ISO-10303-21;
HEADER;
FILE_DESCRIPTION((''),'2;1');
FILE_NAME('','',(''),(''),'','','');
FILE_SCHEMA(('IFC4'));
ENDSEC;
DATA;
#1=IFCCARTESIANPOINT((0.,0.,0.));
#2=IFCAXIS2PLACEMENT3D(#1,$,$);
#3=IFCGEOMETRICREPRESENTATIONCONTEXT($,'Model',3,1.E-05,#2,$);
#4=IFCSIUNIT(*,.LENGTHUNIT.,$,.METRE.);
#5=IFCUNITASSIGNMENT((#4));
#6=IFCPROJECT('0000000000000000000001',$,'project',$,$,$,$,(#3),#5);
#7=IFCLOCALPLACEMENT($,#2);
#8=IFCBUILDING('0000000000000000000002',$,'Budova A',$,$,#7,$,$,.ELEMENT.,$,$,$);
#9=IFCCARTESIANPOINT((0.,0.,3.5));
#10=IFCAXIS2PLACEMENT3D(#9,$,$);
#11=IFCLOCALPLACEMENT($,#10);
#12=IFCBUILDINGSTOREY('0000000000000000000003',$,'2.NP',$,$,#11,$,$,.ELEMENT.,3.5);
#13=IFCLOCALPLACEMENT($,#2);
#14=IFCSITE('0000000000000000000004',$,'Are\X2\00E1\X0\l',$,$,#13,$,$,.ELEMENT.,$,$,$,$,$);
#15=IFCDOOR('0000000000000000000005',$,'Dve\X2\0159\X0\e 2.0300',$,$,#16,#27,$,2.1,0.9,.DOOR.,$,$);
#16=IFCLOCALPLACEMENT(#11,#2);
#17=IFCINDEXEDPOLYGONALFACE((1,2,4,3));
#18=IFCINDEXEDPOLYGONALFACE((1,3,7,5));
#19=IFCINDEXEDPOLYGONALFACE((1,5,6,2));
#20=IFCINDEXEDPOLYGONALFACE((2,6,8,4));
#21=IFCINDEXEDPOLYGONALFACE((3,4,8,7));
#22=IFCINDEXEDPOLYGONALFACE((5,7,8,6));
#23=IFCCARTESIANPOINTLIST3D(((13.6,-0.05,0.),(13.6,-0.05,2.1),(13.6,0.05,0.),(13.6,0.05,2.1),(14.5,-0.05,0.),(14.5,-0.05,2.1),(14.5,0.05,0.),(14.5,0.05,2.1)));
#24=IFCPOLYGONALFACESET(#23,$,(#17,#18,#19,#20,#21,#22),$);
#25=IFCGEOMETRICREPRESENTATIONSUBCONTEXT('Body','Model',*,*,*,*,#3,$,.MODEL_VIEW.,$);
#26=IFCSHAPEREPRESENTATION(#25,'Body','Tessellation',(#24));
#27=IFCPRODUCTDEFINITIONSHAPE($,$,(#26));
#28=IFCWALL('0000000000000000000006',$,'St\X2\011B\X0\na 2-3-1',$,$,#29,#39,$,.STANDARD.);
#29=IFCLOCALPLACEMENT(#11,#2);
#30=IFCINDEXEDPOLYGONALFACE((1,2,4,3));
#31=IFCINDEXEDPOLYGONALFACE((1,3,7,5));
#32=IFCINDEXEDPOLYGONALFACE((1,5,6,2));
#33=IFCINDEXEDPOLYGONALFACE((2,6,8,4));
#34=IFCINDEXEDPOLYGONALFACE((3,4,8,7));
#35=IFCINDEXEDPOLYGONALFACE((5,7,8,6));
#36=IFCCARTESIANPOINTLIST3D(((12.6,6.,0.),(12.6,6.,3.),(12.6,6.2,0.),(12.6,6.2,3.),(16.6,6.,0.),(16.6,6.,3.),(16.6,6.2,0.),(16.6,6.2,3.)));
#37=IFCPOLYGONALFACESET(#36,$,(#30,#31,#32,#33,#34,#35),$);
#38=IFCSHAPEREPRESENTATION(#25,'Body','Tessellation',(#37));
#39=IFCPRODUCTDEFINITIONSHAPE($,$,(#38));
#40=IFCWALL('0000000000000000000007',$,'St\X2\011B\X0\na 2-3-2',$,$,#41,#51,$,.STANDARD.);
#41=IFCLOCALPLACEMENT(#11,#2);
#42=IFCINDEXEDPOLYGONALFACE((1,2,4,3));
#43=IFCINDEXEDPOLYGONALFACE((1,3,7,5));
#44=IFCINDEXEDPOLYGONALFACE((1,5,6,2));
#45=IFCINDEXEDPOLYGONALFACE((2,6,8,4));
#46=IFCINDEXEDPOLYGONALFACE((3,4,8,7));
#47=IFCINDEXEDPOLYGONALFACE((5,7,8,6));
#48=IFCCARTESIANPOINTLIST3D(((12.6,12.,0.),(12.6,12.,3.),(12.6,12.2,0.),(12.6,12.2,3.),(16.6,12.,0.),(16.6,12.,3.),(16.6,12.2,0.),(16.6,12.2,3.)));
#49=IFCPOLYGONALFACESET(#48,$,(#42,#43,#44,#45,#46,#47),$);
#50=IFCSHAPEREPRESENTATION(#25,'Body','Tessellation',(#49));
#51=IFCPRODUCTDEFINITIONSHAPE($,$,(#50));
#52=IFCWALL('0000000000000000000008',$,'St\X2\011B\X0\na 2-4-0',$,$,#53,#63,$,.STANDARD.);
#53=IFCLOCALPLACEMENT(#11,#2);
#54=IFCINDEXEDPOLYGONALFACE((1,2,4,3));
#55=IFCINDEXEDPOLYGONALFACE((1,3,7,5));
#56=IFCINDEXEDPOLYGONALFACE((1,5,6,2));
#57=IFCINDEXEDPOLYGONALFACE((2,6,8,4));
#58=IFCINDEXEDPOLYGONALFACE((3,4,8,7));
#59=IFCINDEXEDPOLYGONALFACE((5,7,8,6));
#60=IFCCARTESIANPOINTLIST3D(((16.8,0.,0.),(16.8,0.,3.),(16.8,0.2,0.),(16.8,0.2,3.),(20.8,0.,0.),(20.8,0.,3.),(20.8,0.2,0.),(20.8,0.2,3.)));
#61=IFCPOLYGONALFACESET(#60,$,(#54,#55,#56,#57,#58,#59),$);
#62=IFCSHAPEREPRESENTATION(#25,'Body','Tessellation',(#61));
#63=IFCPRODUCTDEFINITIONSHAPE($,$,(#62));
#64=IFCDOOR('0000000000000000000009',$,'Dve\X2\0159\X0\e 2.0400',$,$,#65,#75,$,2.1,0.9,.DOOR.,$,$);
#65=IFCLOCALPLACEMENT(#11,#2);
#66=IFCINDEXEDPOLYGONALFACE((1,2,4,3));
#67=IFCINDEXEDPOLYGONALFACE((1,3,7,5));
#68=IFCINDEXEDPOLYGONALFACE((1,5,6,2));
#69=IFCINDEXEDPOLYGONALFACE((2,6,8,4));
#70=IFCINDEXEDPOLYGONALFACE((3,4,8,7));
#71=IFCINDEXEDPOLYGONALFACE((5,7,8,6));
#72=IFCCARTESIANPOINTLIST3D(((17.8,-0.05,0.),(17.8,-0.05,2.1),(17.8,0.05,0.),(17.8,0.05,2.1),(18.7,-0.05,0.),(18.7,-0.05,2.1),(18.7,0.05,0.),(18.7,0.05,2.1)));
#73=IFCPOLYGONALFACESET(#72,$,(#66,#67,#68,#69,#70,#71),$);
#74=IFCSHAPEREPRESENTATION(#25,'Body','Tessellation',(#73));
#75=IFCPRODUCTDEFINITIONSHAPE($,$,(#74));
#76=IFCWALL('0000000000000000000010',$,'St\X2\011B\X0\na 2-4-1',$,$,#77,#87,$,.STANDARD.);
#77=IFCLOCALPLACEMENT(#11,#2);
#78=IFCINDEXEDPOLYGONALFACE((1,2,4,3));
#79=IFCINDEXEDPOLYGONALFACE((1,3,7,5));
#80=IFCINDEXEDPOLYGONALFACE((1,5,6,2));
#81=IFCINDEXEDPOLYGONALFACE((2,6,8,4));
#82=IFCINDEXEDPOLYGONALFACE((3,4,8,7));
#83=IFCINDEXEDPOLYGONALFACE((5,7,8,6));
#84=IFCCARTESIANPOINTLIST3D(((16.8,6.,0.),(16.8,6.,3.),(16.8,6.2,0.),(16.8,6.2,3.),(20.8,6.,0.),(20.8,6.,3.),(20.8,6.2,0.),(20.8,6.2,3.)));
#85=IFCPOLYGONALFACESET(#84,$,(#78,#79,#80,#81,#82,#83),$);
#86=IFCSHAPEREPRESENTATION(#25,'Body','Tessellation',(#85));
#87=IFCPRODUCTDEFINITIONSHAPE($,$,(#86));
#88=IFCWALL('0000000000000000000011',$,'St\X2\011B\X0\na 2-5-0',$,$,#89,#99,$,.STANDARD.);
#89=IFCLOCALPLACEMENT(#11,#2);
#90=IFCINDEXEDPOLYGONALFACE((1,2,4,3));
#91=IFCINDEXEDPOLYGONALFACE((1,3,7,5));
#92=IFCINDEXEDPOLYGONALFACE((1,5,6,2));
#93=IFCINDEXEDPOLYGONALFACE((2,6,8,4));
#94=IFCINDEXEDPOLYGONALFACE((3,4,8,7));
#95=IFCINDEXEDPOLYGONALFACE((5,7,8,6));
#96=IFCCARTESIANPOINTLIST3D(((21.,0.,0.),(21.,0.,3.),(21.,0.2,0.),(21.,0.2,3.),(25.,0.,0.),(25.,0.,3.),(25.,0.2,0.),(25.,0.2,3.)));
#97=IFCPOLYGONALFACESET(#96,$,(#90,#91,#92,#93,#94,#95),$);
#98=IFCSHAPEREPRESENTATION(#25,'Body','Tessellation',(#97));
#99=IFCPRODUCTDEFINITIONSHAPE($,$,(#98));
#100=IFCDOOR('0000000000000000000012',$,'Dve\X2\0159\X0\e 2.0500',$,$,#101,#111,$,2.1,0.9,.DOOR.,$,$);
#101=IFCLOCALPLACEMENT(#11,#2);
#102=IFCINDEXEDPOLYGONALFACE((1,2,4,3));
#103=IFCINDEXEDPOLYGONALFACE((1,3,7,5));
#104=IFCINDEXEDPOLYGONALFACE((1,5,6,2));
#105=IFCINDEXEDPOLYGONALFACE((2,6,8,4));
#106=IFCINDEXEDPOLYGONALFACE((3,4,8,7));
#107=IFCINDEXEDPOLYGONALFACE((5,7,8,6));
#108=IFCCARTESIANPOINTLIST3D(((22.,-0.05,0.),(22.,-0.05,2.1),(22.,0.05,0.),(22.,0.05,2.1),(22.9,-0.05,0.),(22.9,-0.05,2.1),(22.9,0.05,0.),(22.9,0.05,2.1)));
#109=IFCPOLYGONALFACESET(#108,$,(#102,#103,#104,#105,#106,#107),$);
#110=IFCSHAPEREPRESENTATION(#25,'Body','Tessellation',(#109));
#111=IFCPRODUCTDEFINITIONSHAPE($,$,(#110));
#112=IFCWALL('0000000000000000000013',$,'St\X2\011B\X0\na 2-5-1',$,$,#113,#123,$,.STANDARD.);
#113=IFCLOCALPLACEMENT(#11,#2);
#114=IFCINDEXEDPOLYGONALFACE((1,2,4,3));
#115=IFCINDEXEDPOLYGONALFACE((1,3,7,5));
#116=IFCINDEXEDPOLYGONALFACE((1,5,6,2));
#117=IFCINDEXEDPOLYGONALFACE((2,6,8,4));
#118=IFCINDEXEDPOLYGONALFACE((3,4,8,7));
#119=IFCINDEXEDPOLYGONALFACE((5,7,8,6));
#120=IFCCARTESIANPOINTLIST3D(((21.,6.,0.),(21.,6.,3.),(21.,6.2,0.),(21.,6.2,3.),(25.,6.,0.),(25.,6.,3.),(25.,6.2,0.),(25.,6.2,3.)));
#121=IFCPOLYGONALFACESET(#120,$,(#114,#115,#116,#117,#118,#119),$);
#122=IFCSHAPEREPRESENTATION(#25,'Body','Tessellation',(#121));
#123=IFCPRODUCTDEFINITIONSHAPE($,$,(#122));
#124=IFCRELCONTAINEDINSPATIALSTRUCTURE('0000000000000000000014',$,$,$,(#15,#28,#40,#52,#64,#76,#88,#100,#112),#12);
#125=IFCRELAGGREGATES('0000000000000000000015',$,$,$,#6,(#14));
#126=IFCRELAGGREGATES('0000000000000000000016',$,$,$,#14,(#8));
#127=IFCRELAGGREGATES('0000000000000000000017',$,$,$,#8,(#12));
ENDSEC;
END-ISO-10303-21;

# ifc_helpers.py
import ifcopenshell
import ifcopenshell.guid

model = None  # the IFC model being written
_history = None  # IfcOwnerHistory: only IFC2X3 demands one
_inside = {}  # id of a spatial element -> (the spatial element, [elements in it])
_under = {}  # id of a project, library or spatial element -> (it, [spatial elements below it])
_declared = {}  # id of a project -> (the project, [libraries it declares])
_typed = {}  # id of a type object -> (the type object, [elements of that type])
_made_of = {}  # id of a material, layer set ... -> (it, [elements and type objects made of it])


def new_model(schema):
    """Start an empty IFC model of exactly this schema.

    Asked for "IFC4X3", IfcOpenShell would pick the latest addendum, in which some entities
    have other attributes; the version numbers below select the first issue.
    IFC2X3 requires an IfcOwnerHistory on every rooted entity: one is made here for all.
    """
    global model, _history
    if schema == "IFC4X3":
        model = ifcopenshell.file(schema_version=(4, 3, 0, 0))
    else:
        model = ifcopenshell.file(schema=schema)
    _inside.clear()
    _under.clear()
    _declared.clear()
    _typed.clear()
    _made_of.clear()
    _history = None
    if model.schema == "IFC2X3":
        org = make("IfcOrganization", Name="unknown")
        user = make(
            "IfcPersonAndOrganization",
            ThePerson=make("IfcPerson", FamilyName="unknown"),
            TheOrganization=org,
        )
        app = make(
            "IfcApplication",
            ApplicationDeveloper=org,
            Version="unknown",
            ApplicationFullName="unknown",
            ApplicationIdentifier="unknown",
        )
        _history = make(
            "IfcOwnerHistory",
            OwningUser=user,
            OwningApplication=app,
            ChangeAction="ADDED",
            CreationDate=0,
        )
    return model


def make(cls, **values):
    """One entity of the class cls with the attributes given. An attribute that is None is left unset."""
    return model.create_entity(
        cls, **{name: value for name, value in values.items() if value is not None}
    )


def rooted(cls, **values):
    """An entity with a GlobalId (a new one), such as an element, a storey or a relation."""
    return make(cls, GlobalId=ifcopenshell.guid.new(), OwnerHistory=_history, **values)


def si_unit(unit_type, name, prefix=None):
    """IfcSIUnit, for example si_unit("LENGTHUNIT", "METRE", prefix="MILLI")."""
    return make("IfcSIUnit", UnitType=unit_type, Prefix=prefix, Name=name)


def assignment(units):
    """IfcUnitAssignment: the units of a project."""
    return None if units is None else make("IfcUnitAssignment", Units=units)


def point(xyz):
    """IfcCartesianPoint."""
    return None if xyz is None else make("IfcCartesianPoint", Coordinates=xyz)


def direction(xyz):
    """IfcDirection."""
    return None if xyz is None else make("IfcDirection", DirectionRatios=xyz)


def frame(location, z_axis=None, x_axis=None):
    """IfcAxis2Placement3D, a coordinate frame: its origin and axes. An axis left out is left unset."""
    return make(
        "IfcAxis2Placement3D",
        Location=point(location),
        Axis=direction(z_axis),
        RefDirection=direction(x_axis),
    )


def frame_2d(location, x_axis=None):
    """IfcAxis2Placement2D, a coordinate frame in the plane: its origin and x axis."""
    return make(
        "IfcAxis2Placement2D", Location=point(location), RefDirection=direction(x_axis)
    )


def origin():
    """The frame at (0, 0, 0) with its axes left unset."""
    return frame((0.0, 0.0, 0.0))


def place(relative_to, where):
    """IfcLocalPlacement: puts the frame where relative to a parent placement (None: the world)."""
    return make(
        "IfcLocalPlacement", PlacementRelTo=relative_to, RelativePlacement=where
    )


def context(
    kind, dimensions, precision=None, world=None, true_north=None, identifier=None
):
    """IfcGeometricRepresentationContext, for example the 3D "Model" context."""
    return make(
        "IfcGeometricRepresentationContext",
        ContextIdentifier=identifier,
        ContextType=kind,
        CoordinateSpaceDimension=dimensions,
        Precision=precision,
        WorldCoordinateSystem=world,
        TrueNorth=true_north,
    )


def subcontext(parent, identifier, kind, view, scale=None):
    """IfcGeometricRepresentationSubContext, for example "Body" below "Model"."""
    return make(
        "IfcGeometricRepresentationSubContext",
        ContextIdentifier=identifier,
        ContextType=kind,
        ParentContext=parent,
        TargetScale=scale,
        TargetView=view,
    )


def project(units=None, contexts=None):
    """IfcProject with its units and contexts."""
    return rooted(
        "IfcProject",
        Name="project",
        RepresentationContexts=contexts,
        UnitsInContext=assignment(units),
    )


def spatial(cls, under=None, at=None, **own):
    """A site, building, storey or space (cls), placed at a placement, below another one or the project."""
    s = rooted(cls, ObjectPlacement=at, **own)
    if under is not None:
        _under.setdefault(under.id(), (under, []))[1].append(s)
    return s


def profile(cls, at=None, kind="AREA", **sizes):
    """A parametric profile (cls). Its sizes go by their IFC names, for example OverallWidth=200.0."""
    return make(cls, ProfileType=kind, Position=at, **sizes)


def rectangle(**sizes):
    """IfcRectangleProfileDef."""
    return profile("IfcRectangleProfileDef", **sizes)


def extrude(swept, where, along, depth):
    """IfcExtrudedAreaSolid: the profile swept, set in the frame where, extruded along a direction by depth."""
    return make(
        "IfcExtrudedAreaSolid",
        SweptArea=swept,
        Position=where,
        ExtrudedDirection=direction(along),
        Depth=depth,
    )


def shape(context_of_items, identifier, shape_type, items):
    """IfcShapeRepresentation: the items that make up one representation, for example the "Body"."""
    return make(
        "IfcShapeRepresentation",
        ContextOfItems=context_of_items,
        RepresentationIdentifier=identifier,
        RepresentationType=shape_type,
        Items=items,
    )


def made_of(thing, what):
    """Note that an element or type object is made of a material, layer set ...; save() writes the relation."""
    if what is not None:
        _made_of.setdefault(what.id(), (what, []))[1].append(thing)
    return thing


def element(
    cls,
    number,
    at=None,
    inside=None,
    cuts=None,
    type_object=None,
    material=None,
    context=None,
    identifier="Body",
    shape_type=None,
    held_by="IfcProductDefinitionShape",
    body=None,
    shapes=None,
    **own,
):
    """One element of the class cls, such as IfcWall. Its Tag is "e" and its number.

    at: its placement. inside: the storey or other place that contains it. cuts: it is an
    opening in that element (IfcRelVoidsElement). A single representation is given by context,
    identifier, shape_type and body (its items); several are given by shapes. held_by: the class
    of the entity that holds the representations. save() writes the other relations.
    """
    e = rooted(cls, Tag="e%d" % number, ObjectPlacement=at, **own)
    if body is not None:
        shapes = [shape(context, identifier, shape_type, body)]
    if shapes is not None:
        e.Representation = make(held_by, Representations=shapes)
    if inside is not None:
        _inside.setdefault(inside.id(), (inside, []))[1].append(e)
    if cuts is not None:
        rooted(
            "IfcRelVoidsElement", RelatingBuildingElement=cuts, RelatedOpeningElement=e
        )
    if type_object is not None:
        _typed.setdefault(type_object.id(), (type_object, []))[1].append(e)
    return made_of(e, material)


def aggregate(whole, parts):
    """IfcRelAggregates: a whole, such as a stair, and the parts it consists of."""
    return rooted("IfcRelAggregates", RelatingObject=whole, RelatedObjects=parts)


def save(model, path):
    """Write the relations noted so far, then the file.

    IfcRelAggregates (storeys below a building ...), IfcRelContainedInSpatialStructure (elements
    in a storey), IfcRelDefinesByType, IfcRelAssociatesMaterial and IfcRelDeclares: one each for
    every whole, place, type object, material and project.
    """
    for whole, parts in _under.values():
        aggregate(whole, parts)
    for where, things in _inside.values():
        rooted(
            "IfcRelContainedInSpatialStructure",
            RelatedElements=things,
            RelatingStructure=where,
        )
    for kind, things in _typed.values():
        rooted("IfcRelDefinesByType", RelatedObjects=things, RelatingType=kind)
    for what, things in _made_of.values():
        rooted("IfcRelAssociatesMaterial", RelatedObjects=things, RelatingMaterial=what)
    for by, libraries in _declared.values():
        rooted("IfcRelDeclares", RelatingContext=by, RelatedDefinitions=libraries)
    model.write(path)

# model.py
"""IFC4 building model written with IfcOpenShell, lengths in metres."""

from ifc_helpers import new_model, si_unit, frame, frame_2d, origin, place, context, subcontext, project, spatial, rectangle, extrude, element, save


model = new_model("IFC4")

# Units and contexts
model_context = context("Model", 3, precision=1e-05, world=origin())
body_context = subcontext(model_context, "Body", "Model", "MODEL_VIEW")
ifc_project = project(units=[si_unit("LENGTHUNIT", "METRE")], contexts=[model_context])

# Site, building, storey
site_placement = place(None, origin())
site = spatial("IfcSite", under=ifc_project, at=site_placement, Name="Areál", CompositionType="ELEMENT")
building_placement = place(None, origin())
building = spatial("IfcBuilding", under=site, at=building_placement, Name="Budova A", CompositionType="ELEMENT")
storey_placement = place(None, frame((0.0, 0.0, 3.5)))
storey = spatial("IfcBuildingStorey", under=building, at=storey_placement, Name="2.NP", CompositionType="ELEMENT", Elevation=3.5)

# Door
door_1_placement = place(storey_placement, frame((13.6, -0.05, 0.0)))
element("IfcDoor", 1, at=door_1_placement, inside=storey, Name="Dveře 2.0300", OverallHeight=2.1, OverallWidth=0.9, PredefinedType="DOOR", context=body_context, shape_type="SweptSolid", body=[
    extrude(rectangle(XDim=0.9, YDim=0.1, at=frame_2d((0.45, 0.05))), origin(), (0.0, 0.0, 1.0), 2.1),
])

# Walls
for number, where, name in (
    (2, (12.6, 6.0, 0.0), "Stěna 2-3-1"),
    (3, (12.6, 12.0, 0.0), "Stěna 2-3-2"),
    (4, (16.8, 0.0, 0.0), "Stěna 2-4-0"),
):
    element("IfcWall", number, at=place(storey_placement, frame(where)), inside=storey, Name=name, PredefinedType="STANDARD", context=body_context, shape_type="SweptSolid", body=[
        extrude(rectangle(XDim=4.0, YDim=0.2, at=frame_2d((2.0, 0.1))), origin(), (0.0, 0.0, 1.0), 3.0),
    ])

# Door
door_2_placement = place(storey_placement, frame((17.8, -0.05, 0.0)))
element("IfcDoor", 5, at=door_2_placement, inside=storey, Name="Dveře 2.0400", OverallHeight=2.1, OverallWidth=0.9, PredefinedType="DOOR", context=body_context, shape_type="SweptSolid", body=[
    extrude(rectangle(XDim=0.9, YDim=0.1, at=frame_2d((0.45, 0.05))), origin(), (0.0, 0.0, 1.0), 2.1),
])

# Walls
for number, where, name in (
    (6, (16.8, 6.0, 0.0), "Stěna 2-4-1"),
    (7, (21.0, 0.0, 0.0), "Stěna 2-5-0"),
):
    element("IfcWall", number, at=place(storey_placement, frame(where)), inside=storey, Name=name, PredefinedType="STANDARD", context=body_context, shape_type="SweptSolid", body=[
        extrude(rectangle(XDim=4.0, YDim=0.2, at=frame_2d((2.0, 0.1))), origin(), (0.0, 0.0, 1.0), 3.0),
    ])

# Door
door_3_placement = place(storey_placement, frame((22.0, -0.05, 0.0)))
element("IfcDoor", 8, at=door_3_placement, inside=storey, Name="Dveře 2.0500", OverallHeight=2.1, OverallWidth=0.9, PredefinedType="DOOR", context=body_context, shape_type="SweptSolid", body=[
    extrude(rectangle(XDim=0.9, YDim=0.1, at=frame_2d((0.45, 0.05))), origin(), (0.0, 0.0, 1.0), 2.1),
])

# Wall
wall_1_placement = place(storey_placement, frame((21.0, 6.0, 0.0)))
element("IfcWall", 9, at=wall_1_placement, inside=storey, Name="Stěna 2-5-1", PredefinedType="STANDARD", context=body_context, shape_type="SweptSolid", body=[
    extrude(rectangle(XDim=4.0, YDim=0.2, at=frame_2d((2.0, 0.1))), origin(), (0.0, 0.0, 1.0), 3.0),
])

save(model, "model.ifc")
